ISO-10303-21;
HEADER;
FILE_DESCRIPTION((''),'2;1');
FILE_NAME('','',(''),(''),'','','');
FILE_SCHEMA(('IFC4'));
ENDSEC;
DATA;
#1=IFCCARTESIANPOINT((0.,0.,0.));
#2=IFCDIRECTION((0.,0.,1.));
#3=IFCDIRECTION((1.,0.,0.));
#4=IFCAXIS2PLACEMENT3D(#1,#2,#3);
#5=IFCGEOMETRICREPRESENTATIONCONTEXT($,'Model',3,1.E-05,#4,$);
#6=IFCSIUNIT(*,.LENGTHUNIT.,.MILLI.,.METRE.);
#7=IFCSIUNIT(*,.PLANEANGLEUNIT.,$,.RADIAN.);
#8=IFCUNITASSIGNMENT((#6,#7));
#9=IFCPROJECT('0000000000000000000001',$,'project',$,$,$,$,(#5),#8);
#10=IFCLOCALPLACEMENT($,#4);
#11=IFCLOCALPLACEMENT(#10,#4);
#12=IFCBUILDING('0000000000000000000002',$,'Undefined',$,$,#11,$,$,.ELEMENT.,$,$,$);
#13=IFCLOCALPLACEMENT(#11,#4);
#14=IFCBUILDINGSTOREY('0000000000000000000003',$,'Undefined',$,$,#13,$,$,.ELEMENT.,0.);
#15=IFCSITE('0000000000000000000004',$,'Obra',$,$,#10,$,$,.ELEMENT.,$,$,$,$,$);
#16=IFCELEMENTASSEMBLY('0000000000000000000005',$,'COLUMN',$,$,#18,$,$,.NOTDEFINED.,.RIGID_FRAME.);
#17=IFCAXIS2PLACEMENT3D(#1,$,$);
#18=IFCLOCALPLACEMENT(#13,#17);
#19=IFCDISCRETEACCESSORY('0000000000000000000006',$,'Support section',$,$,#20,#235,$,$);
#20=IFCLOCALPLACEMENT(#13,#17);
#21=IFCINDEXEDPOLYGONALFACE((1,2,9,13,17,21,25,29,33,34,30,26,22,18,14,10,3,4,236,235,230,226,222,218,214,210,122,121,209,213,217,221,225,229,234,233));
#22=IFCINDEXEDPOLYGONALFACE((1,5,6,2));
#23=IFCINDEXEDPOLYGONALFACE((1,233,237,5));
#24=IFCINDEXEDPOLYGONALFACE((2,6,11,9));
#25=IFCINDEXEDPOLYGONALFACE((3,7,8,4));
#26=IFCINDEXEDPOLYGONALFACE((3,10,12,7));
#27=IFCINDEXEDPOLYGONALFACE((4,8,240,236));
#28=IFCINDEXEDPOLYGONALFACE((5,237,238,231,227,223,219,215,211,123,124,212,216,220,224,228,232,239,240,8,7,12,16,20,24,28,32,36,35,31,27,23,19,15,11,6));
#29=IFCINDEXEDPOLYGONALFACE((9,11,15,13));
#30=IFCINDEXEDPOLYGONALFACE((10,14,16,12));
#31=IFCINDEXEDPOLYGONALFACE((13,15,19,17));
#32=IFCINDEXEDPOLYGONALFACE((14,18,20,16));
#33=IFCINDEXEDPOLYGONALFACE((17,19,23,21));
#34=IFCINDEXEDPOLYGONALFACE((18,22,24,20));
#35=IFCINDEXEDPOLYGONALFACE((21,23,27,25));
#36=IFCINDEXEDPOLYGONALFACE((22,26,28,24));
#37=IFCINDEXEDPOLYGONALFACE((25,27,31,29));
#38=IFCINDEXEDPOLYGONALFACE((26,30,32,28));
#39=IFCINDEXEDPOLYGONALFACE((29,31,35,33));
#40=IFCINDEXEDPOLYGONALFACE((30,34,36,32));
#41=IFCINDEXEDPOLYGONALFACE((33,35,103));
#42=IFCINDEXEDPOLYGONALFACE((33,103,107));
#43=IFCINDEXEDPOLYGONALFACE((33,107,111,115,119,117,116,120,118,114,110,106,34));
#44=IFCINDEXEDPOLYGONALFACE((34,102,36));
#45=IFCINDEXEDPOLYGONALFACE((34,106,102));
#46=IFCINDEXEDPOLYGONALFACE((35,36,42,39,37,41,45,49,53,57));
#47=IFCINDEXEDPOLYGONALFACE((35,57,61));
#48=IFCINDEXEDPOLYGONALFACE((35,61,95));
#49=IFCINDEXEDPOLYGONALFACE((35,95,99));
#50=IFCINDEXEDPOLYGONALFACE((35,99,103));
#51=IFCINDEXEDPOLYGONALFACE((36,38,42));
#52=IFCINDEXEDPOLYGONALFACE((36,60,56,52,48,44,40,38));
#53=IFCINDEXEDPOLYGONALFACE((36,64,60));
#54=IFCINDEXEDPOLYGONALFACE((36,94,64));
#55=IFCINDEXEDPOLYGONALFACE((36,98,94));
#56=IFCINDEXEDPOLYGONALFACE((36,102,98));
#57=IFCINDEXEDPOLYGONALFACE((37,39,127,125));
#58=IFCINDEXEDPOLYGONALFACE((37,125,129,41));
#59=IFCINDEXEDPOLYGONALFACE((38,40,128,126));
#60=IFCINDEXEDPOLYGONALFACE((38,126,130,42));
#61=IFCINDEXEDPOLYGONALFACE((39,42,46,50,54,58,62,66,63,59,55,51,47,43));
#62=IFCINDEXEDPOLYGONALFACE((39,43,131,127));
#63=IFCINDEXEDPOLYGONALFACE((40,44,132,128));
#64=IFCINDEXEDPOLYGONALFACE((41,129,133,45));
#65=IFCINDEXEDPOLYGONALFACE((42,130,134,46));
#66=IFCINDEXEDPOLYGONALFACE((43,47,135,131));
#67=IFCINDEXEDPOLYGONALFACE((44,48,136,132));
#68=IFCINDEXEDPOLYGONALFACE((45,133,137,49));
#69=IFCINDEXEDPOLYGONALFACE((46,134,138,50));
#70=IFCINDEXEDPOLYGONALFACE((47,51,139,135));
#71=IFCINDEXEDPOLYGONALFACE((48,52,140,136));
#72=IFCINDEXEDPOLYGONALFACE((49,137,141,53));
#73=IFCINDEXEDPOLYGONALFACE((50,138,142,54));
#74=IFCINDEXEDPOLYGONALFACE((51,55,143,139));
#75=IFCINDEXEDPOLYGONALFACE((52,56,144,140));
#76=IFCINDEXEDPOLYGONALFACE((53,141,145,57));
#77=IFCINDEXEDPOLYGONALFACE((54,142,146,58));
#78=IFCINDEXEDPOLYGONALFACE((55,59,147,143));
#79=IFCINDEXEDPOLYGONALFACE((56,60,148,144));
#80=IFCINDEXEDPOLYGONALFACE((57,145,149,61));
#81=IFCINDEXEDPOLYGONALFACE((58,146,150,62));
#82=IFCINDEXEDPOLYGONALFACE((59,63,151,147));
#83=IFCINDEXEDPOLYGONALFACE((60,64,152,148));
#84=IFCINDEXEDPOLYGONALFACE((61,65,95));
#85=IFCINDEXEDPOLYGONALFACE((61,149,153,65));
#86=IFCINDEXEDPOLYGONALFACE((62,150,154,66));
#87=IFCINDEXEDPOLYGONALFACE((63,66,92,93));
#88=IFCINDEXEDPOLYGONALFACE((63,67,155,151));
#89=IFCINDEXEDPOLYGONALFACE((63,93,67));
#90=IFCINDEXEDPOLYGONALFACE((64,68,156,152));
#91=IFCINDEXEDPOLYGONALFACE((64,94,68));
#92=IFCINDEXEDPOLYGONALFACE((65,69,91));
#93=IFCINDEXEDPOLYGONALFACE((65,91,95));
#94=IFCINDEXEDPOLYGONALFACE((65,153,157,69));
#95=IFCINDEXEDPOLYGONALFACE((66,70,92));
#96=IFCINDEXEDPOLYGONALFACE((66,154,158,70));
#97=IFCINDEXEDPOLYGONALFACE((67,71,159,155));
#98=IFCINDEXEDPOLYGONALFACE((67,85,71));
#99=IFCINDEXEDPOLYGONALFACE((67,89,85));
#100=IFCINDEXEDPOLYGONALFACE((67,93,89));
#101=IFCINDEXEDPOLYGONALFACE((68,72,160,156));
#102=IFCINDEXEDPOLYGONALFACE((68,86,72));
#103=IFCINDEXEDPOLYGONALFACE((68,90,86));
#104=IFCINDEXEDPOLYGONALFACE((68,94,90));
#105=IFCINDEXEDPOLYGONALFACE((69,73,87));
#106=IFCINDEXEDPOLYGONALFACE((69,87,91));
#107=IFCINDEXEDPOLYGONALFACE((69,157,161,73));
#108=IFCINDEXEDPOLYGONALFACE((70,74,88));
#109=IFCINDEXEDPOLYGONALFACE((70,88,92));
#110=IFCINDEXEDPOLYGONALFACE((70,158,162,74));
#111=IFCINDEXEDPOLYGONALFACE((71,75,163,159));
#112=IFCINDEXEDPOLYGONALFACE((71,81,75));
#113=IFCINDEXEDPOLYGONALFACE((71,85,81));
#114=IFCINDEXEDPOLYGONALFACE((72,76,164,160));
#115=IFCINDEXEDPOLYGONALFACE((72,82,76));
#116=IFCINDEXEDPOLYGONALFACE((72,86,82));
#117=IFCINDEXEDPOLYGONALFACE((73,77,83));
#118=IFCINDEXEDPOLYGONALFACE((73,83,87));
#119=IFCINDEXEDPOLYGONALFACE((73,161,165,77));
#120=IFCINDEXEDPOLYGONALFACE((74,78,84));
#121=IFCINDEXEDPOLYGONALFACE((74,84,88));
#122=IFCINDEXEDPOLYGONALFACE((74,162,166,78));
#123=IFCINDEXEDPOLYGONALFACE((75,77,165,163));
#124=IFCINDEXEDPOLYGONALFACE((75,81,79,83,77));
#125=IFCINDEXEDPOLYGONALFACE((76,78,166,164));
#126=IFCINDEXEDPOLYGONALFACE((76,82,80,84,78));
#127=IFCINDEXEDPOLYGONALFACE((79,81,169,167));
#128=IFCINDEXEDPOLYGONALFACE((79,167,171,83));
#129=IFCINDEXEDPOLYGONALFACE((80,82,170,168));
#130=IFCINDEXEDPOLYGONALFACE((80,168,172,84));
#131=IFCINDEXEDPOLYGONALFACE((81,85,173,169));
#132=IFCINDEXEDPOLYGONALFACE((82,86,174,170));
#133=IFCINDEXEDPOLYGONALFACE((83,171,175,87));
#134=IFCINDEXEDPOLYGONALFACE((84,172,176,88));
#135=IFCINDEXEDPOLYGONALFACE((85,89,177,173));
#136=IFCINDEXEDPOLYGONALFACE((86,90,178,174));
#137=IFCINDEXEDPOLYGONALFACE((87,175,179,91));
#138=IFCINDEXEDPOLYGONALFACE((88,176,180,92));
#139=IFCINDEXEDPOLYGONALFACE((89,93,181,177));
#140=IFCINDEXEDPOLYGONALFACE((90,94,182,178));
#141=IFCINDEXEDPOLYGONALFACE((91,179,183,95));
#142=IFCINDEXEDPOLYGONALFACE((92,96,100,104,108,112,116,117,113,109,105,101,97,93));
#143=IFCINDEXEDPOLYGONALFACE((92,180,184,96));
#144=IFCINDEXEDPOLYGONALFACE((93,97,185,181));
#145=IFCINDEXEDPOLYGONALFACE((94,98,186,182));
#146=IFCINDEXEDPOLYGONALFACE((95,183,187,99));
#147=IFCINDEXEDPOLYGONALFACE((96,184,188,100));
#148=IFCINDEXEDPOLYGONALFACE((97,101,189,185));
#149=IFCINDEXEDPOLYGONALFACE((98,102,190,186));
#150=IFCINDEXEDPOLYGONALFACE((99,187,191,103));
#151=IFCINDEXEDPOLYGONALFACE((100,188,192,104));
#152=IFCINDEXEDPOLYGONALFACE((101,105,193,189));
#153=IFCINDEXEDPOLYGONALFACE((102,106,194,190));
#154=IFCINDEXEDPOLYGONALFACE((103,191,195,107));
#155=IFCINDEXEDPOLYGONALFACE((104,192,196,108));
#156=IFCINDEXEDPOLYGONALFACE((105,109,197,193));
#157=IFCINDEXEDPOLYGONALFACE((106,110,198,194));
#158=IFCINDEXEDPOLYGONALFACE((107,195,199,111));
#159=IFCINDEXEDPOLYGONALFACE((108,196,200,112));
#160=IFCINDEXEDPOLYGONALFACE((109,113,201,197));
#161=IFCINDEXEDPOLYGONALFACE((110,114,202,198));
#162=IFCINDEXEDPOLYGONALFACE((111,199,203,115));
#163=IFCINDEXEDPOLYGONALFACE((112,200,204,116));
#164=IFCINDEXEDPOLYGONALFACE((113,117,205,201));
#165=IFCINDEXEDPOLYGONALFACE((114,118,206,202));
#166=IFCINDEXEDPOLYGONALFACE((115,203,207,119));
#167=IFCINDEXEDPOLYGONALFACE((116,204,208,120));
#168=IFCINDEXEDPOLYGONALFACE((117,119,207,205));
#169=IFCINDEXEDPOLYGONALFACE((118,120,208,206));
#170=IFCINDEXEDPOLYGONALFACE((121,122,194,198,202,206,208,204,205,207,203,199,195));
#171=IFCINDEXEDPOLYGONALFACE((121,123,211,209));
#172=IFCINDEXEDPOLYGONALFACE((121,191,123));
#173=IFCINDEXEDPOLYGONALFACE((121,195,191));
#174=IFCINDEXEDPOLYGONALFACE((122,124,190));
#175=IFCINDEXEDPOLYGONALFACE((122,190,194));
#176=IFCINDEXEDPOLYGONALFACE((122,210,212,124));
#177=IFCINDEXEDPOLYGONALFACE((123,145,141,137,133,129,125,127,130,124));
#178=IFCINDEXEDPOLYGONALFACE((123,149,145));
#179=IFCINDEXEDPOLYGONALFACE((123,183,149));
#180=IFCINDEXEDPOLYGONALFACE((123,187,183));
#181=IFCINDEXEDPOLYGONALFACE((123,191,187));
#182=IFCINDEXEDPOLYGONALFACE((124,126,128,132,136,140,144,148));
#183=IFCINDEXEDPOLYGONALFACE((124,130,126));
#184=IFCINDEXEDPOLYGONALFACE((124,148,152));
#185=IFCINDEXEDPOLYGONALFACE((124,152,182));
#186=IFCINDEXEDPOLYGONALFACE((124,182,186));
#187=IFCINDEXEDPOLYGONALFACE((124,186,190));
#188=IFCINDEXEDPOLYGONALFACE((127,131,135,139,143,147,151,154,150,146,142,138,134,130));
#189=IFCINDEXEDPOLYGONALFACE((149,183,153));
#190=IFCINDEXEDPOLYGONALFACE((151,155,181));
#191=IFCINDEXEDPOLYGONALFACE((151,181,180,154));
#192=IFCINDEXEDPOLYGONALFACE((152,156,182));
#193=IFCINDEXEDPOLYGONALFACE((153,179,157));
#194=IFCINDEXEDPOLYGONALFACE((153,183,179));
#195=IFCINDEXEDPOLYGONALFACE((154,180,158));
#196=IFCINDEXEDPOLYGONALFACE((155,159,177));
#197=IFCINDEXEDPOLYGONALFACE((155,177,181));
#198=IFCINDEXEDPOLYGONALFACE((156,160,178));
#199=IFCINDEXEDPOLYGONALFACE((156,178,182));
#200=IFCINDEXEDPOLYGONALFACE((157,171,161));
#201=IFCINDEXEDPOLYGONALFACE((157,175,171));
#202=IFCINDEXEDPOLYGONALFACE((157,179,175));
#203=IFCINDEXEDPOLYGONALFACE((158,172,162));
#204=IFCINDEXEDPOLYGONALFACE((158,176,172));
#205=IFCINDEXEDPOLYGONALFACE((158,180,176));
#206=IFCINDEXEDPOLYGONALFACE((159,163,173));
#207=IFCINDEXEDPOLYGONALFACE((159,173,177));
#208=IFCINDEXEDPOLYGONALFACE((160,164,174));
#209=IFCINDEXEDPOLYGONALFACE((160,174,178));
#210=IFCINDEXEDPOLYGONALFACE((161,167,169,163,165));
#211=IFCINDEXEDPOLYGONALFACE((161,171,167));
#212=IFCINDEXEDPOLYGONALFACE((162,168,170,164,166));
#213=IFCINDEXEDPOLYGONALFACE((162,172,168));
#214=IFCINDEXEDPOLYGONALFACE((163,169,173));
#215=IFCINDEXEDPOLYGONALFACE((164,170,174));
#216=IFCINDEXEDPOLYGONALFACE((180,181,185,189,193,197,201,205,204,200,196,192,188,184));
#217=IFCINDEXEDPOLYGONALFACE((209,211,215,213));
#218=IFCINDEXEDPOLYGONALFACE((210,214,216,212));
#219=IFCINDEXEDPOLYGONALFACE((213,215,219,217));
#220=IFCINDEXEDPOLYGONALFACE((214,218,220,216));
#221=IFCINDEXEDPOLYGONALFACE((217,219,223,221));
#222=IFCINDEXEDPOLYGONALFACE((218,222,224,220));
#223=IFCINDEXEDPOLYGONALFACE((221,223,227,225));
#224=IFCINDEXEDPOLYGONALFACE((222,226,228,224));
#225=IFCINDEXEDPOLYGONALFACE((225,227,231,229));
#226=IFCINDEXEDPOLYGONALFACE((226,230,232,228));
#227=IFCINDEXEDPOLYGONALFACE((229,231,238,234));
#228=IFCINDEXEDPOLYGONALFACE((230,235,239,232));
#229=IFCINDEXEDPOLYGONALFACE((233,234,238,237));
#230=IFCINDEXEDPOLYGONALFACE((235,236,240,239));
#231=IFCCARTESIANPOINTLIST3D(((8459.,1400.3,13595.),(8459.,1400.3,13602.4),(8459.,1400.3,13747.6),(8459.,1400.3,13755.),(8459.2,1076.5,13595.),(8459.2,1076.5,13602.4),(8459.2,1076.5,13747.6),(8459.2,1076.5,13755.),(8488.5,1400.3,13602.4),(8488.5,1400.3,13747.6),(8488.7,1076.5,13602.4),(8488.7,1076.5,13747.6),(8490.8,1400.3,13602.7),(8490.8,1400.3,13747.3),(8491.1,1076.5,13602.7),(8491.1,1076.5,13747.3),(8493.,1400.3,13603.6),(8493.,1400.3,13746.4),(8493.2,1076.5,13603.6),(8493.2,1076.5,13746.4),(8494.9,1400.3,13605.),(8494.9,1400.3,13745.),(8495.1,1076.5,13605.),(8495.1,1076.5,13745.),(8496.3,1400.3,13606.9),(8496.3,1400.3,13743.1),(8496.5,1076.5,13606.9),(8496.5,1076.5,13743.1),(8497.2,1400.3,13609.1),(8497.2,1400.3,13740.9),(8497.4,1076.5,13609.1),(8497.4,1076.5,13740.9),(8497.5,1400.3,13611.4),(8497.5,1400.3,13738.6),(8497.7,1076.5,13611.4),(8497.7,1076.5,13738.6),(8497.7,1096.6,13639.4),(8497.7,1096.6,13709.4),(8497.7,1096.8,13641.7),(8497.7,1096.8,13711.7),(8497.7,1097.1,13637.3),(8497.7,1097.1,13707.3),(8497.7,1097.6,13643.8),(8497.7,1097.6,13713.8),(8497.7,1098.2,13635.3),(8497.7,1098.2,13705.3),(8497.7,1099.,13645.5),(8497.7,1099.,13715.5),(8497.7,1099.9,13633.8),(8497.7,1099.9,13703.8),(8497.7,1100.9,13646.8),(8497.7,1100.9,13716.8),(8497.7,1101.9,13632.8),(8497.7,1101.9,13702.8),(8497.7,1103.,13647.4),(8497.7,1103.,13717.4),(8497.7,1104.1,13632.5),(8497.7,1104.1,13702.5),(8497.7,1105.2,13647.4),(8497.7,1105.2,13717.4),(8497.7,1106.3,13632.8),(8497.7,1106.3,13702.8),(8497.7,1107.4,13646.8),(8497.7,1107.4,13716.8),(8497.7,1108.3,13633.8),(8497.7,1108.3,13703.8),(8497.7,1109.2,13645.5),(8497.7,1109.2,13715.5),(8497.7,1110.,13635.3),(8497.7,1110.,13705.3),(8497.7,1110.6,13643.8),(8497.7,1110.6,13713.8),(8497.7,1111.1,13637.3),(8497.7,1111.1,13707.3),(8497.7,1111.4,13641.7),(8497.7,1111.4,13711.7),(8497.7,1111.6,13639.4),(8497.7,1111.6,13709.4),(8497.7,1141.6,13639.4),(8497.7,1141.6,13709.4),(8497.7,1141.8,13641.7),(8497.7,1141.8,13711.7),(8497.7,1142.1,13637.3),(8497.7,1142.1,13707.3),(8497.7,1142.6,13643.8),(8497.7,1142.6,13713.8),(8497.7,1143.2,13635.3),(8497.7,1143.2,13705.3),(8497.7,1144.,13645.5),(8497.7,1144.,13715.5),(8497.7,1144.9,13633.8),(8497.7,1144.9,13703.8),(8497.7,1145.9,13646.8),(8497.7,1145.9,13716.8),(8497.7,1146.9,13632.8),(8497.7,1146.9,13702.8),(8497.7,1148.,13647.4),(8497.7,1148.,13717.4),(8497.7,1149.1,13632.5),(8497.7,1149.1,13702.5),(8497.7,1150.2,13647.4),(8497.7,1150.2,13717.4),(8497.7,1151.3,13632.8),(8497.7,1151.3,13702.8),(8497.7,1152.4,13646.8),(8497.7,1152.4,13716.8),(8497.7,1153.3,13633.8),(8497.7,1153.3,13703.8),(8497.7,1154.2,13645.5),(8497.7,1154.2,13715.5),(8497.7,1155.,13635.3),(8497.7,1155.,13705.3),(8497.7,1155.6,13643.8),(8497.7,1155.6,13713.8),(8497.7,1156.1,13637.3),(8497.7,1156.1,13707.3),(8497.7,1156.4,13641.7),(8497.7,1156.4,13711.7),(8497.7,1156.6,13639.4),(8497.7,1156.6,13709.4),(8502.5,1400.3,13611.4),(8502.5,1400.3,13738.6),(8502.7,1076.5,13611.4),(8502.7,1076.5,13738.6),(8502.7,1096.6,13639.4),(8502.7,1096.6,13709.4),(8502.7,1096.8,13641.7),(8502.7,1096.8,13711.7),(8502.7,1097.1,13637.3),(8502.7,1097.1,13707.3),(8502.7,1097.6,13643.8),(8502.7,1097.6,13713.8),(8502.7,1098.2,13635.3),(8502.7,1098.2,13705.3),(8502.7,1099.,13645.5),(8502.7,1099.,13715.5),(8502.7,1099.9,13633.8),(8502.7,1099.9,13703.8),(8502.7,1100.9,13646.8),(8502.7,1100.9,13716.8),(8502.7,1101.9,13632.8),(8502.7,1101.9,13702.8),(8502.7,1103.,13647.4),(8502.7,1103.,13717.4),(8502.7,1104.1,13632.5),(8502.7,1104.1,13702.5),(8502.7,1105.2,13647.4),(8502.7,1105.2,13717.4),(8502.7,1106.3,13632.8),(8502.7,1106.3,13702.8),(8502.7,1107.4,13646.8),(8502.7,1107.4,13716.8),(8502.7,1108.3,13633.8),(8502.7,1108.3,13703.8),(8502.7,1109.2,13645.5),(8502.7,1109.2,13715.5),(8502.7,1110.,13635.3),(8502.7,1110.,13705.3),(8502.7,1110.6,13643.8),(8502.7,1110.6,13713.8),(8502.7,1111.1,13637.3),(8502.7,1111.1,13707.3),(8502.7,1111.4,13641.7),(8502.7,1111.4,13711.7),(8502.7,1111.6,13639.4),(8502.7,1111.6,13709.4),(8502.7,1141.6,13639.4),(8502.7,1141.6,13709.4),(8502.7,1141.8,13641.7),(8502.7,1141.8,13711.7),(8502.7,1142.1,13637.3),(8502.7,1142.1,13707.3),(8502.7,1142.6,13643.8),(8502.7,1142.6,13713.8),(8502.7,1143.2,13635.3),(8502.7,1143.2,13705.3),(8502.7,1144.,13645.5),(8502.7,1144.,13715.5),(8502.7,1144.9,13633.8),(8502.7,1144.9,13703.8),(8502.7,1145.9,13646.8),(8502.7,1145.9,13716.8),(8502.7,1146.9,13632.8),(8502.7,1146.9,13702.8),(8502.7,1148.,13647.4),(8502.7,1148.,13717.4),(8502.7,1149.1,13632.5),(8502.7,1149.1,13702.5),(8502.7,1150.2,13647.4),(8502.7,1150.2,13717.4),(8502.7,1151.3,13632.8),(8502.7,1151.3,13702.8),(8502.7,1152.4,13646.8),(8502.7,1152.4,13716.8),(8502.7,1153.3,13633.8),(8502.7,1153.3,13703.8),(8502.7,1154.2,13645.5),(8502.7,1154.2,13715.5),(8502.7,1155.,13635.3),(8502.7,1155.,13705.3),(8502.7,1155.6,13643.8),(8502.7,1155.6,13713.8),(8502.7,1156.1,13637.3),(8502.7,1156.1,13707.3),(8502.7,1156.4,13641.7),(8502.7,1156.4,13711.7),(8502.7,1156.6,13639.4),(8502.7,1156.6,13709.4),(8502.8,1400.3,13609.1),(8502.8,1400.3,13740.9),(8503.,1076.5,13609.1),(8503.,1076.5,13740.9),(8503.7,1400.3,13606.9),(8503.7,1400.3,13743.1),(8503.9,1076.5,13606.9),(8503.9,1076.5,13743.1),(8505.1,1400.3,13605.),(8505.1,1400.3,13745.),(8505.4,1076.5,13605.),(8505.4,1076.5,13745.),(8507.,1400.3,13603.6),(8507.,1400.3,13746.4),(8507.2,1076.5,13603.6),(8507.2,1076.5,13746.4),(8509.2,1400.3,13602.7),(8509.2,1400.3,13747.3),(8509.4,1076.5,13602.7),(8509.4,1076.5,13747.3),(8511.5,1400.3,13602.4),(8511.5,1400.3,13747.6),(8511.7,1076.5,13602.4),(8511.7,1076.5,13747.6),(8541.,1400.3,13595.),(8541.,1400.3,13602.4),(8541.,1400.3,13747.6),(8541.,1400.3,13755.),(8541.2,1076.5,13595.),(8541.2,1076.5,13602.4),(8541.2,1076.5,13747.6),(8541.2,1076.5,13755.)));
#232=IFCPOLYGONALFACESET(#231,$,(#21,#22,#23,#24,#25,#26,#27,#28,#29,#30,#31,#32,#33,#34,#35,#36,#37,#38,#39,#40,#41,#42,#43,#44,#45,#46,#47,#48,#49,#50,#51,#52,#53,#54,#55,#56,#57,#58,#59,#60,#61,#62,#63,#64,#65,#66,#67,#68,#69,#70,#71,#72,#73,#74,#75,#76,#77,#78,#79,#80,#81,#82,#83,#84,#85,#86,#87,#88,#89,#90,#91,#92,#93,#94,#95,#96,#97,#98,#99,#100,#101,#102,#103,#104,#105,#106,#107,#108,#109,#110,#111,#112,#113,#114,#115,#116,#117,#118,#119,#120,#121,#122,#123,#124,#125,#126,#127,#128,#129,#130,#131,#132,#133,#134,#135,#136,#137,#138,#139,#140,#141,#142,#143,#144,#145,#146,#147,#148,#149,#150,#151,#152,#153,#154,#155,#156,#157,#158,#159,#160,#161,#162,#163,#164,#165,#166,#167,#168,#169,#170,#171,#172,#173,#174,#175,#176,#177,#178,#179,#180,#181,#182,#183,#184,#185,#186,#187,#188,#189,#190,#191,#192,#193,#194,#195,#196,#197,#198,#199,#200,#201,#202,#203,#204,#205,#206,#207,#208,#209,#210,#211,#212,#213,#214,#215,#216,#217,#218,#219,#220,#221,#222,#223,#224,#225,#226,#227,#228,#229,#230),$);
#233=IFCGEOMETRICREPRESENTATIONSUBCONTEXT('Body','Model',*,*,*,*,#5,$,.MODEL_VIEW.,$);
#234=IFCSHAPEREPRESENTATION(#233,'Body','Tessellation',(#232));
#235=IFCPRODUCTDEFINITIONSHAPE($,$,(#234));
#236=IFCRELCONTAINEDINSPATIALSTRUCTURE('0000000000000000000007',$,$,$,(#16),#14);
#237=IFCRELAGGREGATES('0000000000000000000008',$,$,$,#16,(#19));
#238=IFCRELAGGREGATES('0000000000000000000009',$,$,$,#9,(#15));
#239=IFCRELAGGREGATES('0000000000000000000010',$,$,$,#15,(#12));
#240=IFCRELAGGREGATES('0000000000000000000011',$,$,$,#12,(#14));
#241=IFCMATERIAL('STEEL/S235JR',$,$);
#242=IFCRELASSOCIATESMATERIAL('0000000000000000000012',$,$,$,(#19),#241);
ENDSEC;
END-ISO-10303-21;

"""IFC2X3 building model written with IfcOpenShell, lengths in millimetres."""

from ifc_helpers import new_model, si_unit, frame, origin_with_axes, origin_2d_with_axis, place, context, subcontext, project, spatial, circle, i_section, extrude, clip, halfspace, source, transform, mapped, material, element, aggregate, save


model = new_model("IFC2X3")

# Units and contexts
model_context = context("Model", 3, precision=1e-05, world=origin_with_axes())
body_context = subcontext(model_context, "Body", "Model", "MODEL_VIEW")
ifc_project = project(units=[si_unit("LENGTHUNIT", "METRE", prefix="MILLI"), si_unit("PLANEANGLEUNIT", "RADIAN")], contexts=[model_context])

# Site, building, storey
site_placement = place(None, origin_with_axes())
site = spatial("IfcSite", under=ifc_project, at=site_placement, Name="Obra", CompositionType="ELEMENT")
building_placement = place(site_placement, origin_with_axes())
building = spatial("IfcBuilding", under=site, at=building_placement, Name="Undefined", CompositionType="ELEMENT")
storey_placement = place(building_placement, origin_with_axes())
storey = spatial("IfcBuildingStorey", under=building, at=storey_placement, Name="Undefined", CompositionType="ELEMENT", Elevation=0.0)

# Element assembly
assembly_1_placement = place(storey_placement, origin_with_axes())
assembly_1 = element("IfcElementAssembly", 1, at=assembly_1_placement, inside=storey, Name="COLUMN", AssemblyPlace="NOTDEFINED", PredefinedType="RIGID_FRAME")
ifc_material_1 = material(Name="STEEL/S235JR")

# Discrete accessory, opening
discrete_accessory_1_placement = place(assembly_1_placement, frame((8500.2, 1086.6, 13675.0), z_axis=(0.0, 0.0, 1.0), x_axis=(-0.000732, 1.0, 0.0)))
discrete_accessory_1 = element("IfcDiscreteAccessory", 2, at=discrete_accessory_1_placement, material=ifc_material_1, Name="Support section", context=body_context, shape_type="Clipping", body=[
    clip(extrude(i_section(OverallWidth=82.0, OverallDepth=160.0, WebThickness=5.0, FlangeThickness=7.4, FilletRadius=9.0, at=origin_2d_with_axis()), frame((313.7, 0.0, 0.0), z_axis=(-1.0, 0.0, 0.0), x_axis=(0.0, -1.0, 0.0)), (0.0, 0.0, 1.0), 323.8), halfspace(frame((-10.0, 0.0, -180.0), z_axis=(1.0, -0.000732, 0.0), x_axis=(-0.000732, -1.0, 0.0)), True)),
])
shared_shape_1 = source(origin_with_axes(), body_context, "Body", "SweptSolid", [
    extrude(circle(Radius=7.5, at=origin_2d_with_axis()), frame((0.0, -2.6, 0.0), z_axis=(0.0, 1.0, 0.0), x_axis=(1.0, 0.0, 0.0)), (0.0, 0.0, 1.0), 5.2),
])
opening_1_placement = place(assembly_1_placement, frame((8500.3, 1126.6, 13710.0), z_axis=(0.0, 1.0, 0.0), x_axis=(0.0, 0.0, -1.0)))
element("IfcOpeningElement", 3, at=opening_1_placement, cuts=discrete_accessory_1, ObjectType="Opening", context=body_context, shape_type="MappedRepresentation", body=[
    mapped(shared_shape_1, transform((0.0, 0.0, -22.5))),
    mapped(shared_shape_1, transform((70.0, 0.0, -22.5))),
    mapped(shared_shape_1, transform((0.0, 0.0, 22.5))),
    mapped(shared_shape_1, transform((70.0, 0.0, 22.5))),
])
aggregate(assembly_1, [discrete_accessory_1])

save(model, "model.ifc")
